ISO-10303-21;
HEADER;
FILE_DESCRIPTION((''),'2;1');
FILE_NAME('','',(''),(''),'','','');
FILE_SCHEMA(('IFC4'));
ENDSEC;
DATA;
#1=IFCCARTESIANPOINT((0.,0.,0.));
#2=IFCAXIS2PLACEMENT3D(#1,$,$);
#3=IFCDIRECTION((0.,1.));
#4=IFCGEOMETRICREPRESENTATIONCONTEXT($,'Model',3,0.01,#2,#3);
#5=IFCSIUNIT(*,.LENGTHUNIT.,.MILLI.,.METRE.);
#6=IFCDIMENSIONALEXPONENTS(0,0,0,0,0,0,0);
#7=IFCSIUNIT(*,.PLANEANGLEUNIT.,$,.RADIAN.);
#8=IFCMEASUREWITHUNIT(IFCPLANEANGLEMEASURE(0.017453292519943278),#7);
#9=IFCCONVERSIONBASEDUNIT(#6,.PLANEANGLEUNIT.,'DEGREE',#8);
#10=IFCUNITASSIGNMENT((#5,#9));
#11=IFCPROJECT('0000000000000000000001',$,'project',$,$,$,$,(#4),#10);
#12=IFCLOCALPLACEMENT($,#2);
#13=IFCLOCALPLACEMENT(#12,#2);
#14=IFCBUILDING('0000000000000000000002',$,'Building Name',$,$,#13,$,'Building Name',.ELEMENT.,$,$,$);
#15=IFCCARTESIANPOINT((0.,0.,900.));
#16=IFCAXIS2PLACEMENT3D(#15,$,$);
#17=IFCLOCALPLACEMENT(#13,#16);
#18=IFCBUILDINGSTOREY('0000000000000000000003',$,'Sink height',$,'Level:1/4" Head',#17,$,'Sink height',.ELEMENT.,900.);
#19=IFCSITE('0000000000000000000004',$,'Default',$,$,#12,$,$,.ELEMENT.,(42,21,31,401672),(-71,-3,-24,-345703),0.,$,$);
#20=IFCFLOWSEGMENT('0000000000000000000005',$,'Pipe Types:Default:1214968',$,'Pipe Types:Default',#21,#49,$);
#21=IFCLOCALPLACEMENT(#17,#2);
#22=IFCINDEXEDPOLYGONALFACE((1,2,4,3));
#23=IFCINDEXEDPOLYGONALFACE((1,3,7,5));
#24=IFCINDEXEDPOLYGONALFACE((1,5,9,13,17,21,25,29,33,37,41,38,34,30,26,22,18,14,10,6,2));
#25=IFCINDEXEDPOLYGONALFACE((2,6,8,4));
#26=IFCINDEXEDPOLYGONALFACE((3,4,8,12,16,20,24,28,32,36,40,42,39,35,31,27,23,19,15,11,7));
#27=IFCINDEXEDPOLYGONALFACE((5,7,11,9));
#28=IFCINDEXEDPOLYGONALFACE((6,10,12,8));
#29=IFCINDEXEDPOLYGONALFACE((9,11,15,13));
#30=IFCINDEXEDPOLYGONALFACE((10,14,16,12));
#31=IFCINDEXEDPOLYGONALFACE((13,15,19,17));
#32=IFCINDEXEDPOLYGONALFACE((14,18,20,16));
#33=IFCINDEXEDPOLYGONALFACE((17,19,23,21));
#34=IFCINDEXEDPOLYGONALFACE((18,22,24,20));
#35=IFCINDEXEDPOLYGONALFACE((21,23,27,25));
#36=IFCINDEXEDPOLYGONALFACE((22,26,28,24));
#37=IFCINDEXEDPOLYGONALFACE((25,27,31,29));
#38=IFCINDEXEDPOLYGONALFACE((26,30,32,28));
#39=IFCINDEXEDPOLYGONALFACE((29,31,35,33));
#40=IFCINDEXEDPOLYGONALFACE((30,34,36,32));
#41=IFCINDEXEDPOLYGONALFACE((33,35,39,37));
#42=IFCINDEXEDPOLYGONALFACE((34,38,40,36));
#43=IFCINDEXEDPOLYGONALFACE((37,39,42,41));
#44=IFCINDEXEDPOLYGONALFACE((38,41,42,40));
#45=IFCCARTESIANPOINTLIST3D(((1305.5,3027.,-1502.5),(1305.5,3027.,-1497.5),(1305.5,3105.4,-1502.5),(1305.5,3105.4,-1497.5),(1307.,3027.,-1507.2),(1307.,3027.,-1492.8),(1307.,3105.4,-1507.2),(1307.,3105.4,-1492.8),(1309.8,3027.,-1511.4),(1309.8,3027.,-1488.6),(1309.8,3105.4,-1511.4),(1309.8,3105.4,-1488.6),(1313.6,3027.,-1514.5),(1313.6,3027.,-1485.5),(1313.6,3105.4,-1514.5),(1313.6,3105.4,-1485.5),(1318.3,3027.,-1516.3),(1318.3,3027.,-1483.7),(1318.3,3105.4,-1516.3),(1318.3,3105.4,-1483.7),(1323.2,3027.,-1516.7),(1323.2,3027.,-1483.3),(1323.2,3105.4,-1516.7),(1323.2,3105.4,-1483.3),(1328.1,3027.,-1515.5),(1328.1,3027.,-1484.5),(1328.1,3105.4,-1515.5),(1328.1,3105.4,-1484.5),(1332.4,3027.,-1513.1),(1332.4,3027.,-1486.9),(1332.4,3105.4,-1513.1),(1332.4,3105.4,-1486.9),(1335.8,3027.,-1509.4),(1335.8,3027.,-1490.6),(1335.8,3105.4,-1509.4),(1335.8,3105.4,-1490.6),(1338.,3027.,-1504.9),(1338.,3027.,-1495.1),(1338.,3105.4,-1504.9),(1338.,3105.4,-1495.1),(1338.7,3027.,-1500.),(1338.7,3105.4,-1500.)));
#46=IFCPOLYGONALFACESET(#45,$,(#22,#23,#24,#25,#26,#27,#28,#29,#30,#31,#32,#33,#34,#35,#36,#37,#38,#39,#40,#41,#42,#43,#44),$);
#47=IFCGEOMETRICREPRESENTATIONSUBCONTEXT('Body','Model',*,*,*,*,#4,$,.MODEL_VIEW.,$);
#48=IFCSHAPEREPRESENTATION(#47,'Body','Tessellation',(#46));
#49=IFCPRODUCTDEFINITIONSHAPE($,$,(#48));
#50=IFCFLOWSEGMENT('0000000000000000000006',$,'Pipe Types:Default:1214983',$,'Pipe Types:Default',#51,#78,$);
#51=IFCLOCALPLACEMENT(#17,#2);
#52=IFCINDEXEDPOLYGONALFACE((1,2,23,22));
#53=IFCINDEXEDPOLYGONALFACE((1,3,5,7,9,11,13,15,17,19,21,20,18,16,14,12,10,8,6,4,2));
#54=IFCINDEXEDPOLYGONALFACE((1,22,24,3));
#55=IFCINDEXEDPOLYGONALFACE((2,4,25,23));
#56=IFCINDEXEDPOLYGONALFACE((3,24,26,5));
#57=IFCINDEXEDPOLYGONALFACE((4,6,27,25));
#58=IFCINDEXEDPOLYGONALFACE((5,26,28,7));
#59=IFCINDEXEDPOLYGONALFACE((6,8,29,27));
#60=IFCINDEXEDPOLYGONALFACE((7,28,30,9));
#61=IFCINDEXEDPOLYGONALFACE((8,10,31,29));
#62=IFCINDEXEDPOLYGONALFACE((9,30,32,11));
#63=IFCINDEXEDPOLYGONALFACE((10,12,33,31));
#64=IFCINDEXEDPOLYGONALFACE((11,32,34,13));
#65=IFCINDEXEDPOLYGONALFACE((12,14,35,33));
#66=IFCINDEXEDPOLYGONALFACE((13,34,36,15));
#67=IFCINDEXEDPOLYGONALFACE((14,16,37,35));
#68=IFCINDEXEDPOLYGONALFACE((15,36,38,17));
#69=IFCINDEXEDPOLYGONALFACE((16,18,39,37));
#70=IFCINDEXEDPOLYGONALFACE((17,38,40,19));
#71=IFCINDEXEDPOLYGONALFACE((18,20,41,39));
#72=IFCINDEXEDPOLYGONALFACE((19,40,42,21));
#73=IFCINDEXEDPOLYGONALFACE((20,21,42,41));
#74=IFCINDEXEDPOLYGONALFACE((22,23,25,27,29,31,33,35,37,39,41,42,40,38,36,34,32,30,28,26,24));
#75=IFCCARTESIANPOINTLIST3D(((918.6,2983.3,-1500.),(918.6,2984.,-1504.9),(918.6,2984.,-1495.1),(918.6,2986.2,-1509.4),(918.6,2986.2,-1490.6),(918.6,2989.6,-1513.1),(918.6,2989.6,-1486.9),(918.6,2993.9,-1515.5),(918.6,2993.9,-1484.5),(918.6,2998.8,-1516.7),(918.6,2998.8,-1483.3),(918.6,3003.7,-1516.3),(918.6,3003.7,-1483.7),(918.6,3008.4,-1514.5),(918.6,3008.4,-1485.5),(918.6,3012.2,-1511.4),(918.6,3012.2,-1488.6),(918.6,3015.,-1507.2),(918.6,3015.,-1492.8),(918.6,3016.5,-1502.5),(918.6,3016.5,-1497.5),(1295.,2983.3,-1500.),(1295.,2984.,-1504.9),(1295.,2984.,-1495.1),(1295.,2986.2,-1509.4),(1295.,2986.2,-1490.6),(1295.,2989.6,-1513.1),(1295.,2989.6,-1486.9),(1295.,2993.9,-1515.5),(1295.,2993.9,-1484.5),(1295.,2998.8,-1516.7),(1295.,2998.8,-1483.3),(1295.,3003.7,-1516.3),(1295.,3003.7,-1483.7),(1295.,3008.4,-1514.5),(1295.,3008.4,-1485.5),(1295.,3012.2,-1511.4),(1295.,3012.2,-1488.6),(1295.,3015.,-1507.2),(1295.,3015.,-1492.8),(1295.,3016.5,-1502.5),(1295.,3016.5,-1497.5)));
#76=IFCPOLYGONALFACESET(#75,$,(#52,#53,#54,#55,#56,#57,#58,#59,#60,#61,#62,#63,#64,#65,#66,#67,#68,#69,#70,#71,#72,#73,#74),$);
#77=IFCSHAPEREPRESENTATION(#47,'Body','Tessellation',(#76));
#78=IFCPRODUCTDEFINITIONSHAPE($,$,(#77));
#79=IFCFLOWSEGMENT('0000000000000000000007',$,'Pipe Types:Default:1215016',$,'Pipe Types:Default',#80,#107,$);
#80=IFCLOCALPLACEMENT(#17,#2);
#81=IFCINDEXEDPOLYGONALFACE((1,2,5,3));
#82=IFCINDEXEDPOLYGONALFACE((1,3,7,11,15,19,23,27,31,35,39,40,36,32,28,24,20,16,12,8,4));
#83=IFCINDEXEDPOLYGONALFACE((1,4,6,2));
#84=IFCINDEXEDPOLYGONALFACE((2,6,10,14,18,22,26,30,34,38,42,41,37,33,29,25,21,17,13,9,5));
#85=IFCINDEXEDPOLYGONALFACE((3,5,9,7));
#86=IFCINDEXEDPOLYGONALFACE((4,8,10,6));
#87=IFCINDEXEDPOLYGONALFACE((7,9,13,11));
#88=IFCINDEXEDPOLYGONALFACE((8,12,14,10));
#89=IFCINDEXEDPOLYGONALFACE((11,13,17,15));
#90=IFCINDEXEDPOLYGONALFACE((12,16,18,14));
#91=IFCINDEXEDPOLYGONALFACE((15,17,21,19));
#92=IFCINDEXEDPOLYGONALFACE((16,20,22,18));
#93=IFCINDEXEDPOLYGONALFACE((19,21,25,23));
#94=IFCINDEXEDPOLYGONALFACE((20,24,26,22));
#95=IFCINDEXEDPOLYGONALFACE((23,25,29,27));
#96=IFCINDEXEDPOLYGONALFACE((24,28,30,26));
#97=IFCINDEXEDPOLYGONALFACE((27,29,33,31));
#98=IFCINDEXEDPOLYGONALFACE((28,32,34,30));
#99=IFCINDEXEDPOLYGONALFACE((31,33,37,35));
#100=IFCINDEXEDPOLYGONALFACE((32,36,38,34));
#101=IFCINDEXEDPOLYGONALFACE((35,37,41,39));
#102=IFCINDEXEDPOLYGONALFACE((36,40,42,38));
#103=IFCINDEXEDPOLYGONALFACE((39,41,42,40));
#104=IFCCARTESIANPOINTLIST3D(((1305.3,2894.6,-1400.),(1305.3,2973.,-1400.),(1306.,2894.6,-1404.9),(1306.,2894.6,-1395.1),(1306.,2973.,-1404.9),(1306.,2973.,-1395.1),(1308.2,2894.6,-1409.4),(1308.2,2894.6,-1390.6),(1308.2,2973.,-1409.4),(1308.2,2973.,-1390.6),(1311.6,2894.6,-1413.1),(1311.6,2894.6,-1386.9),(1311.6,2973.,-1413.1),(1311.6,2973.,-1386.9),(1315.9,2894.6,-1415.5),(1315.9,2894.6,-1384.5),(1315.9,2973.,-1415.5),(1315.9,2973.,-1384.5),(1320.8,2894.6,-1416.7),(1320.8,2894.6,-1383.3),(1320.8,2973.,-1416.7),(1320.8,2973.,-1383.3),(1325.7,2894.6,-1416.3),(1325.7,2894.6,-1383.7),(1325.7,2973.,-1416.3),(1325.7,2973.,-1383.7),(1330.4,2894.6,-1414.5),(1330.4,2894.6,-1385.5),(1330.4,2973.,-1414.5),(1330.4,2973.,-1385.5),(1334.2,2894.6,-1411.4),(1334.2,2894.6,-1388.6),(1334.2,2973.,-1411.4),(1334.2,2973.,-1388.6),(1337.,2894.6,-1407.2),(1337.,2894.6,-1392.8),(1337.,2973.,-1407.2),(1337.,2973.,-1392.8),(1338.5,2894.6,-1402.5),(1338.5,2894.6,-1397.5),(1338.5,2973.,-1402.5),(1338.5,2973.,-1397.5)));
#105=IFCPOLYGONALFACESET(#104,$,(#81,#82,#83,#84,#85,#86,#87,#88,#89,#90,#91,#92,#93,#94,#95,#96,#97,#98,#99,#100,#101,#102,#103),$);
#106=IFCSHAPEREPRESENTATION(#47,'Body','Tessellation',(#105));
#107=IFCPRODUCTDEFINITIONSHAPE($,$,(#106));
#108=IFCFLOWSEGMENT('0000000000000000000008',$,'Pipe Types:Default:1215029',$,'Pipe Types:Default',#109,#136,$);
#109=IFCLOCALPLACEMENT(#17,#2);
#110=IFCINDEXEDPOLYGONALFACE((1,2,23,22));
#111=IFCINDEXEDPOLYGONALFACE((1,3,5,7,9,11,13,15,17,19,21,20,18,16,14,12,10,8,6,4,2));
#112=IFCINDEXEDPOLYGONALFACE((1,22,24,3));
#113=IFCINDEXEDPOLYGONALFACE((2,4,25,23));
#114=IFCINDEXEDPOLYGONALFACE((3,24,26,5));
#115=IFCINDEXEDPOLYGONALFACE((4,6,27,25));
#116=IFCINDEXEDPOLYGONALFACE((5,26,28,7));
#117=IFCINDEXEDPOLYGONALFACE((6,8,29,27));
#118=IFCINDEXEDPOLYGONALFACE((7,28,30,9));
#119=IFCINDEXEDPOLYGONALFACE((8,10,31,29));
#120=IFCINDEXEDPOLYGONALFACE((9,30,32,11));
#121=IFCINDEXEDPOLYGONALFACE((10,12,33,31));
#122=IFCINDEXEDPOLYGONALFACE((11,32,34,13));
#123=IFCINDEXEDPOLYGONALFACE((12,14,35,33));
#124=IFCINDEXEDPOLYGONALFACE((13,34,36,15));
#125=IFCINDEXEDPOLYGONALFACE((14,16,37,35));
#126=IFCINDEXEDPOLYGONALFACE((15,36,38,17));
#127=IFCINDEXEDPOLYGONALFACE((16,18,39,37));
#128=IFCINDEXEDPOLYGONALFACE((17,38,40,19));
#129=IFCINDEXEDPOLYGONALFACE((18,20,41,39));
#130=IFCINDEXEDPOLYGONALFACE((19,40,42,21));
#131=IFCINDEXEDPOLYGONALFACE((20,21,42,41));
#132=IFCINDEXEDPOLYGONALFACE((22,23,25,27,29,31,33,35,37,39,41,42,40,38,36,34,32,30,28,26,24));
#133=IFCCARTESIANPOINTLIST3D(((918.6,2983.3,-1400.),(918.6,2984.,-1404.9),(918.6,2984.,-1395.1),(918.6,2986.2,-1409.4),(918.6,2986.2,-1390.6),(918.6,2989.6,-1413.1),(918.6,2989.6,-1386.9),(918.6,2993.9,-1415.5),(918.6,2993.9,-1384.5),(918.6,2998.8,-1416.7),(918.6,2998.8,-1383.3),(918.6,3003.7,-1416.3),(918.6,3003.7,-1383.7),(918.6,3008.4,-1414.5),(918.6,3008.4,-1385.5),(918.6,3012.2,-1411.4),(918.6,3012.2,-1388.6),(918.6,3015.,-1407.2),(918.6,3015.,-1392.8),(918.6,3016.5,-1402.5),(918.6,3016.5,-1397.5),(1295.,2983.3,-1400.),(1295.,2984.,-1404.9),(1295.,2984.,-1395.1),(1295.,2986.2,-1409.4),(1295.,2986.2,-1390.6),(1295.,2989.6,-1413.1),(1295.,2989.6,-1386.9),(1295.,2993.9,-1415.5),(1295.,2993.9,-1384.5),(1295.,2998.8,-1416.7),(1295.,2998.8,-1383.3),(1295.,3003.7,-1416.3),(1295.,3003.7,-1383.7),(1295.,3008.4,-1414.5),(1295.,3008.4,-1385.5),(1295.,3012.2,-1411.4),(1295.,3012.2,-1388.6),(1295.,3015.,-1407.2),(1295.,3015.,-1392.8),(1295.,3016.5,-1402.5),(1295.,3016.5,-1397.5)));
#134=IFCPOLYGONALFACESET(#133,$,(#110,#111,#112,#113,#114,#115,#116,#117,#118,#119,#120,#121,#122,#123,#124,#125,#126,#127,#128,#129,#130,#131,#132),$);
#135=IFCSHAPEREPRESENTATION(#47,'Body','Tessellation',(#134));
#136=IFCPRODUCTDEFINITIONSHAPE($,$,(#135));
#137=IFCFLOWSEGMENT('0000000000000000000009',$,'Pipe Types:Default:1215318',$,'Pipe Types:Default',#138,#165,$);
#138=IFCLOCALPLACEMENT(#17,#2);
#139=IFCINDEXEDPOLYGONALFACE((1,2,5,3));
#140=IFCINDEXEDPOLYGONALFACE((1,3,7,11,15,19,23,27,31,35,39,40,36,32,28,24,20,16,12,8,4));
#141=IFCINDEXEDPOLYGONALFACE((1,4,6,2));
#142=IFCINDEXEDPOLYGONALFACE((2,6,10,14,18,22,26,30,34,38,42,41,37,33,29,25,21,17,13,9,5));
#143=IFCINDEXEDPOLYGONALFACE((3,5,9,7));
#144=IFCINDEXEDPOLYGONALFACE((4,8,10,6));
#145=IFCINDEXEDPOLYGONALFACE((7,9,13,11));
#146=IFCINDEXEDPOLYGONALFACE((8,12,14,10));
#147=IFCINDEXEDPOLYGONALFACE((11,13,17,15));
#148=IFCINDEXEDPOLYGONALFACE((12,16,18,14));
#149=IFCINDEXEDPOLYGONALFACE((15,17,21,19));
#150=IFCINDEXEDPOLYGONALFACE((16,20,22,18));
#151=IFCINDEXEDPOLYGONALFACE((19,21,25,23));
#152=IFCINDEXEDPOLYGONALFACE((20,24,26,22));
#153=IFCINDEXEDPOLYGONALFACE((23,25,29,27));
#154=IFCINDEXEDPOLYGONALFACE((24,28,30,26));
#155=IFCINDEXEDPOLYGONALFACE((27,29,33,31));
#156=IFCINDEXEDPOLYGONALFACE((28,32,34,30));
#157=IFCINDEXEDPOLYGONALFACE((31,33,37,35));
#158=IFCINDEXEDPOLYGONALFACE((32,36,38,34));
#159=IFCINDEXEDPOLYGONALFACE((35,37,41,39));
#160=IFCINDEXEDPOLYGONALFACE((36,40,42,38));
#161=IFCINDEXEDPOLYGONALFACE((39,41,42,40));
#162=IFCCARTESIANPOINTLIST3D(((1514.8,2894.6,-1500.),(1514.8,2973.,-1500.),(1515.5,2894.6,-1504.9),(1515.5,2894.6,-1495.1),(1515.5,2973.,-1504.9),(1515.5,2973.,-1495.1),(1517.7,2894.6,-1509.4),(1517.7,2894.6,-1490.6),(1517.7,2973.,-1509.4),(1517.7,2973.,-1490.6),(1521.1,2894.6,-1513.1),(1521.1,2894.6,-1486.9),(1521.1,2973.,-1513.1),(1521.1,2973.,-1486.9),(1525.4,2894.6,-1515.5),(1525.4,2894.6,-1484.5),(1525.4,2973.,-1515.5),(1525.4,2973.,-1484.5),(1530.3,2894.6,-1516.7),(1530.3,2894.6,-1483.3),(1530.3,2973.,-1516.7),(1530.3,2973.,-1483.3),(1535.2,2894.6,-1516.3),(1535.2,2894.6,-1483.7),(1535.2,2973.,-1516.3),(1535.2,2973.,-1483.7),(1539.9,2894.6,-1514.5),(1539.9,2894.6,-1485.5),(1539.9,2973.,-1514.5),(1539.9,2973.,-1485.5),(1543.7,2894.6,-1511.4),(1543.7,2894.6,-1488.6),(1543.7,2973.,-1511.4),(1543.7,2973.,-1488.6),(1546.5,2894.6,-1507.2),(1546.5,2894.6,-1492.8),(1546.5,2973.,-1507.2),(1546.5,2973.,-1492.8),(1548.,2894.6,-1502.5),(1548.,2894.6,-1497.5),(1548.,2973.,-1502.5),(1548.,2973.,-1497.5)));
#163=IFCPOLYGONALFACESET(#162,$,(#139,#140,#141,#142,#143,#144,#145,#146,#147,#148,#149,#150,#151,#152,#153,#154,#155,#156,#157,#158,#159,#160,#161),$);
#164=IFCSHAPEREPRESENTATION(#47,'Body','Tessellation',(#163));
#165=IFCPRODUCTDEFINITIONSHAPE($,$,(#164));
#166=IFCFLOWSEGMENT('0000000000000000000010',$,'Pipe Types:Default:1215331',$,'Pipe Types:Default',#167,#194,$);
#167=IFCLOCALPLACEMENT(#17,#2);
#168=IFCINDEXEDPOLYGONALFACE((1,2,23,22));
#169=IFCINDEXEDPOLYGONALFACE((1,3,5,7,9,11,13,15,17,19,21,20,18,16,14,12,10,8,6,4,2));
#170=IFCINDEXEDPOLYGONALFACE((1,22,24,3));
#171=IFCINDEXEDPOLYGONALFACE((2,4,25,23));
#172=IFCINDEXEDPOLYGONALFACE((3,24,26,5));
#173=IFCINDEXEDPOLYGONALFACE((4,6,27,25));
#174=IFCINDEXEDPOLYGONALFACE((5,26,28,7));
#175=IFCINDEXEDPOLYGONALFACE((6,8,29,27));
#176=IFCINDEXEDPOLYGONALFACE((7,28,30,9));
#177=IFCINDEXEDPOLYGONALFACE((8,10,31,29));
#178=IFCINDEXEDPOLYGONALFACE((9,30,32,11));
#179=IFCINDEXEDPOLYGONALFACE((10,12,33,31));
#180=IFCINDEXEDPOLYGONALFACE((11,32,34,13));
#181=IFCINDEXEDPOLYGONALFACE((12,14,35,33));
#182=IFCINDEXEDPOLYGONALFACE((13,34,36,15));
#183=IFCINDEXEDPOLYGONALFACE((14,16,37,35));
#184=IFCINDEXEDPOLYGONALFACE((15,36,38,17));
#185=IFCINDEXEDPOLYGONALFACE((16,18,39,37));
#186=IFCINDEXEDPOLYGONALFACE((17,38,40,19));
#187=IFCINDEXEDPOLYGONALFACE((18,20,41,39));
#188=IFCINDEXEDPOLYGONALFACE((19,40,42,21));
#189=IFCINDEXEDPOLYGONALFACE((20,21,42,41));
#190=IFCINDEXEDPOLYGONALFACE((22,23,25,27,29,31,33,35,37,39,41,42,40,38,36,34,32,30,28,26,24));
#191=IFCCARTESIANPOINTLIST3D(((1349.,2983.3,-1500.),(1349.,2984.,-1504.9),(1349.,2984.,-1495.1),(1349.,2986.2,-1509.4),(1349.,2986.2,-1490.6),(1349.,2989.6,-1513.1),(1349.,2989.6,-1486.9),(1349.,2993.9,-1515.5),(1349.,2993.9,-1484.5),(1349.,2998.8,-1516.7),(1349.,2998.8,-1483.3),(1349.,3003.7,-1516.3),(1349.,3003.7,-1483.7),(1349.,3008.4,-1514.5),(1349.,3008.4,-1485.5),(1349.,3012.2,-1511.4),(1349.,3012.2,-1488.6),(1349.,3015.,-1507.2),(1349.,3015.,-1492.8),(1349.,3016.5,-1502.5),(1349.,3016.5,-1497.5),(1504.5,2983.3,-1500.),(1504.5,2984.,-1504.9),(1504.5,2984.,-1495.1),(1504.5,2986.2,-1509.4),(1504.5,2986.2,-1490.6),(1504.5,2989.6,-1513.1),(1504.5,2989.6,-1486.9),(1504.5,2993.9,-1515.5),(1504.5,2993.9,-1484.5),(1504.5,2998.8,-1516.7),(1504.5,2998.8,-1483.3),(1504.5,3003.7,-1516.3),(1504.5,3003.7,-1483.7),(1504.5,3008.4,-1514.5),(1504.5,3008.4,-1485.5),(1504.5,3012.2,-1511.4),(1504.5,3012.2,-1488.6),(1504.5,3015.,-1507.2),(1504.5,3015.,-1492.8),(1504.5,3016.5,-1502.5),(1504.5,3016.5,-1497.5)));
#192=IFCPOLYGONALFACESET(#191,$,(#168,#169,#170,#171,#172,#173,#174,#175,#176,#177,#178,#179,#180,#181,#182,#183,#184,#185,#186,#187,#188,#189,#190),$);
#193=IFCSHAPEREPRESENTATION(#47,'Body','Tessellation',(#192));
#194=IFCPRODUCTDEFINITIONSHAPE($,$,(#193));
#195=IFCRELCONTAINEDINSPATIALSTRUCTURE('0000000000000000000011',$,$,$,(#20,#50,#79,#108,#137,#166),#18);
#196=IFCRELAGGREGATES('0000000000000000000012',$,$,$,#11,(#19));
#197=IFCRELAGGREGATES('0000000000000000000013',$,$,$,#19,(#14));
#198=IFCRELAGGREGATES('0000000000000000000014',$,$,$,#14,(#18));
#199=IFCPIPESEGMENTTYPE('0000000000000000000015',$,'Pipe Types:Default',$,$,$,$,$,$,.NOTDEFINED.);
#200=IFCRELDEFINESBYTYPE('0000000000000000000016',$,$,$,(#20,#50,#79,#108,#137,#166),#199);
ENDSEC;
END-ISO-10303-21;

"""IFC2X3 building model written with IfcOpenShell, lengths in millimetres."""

from ifc_helpers import new_model, entity, si_unit, converted_unit, direction, frame, frame_2d, origin, origin_2d_with_axis, place, context, subcontext, project, spatial, circle, extrude, type_object, element, save


model = new_model("IFC2X3")

# Units and contexts
model_context = context("Model", 3, precision=0.01, world=origin(), true_north=direction((0.0, 1.0)))
body_context = subcontext(model_context, "Body", "Model", "MODEL_VIEW")
ifc_project = project(units=[si_unit("LENGTHUNIT", "METRE", prefix="MILLI"), converted_unit("PLANEANGLEUNIT", "DEGREE", entity("IfcPlaneAngleMeasure", 0.017453292519943278), si_unit("PLANEANGLEUNIT", "RADIAN"), dimensions=[0, 0, 0, 0, 0, 0, 0])], contexts=[model_context])

# Site, building, storey
site_placement = place(None, origin())
site = spatial("IfcSite", under=ifc_project, at=site_placement, Name="Default", CompositionType="ELEMENT", RefLatitude=(42, 21, 31, 401672), RefLongitude=(-71, -3, -24, -345703), RefElevation=0.0)
building_placement = place(site_placement, origin())
building = spatial("IfcBuilding", under=site, at=building_placement, Name="Building Name", LongName="Building Name", CompositionType="ELEMENT")
storey_placement = place(building_placement, frame((0.0, 0.0, 900.0)))
storey = spatial("IfcBuildingStorey", under=building, at=storey_placement, Name="Sink height", ObjectType="Level:1/4\" Head", LongName="Sink height", CompositionType="ELEMENT", Elevation=900.0)

# Flow segments
pipe_segment_type = type_object("IfcPipeSegmentType", Name="Pipe Types:Default", PredefinedType="NOTDEFINED")
flow_segment_1_placement = place(storey_placement, origin())
element("IfcFlowSegment", 1, at=flow_segment_1_placement, inside=storey, type_object=pipe_segment_type, Name="Pipe Types:Default:1214968", ObjectType="Pipe Types:Default", context=body_context, shape_type="SweptSolid", body=[
    extrude(circle(Radius=16.7, at=origin_2d_with_axis()), frame((1322.0, 3027.0, -1500.0), z_axis=(0.0, 1.0, 0.0), x_axis=(1.0, 0.0, 0.0)), (0.0, 0.0, 1.0), 78.4),
])
flow_segment_2_placement = place(storey_placement, origin())
element("IfcFlowSegment", 2, at=flow_segment_2_placement, inside=storey, type_object=pipe_segment_type, Name="Pipe Types:Default:1214983", ObjectType="Pipe Types:Default", context=body_context, shape_type="SweptSolid", body=[
    extrude(circle(Radius=16.7, at=origin_2d_with_axis()), frame((918.6, 3000.0, -1500.0), z_axis=(1.0, 0.0, 0.0), x_axis=(0.0, -1.0, 0.0)), (0.0, 0.0, 1.0), 376.5),
])
flow_segment_3_placement = place(storey_placement, origin())
element("IfcFlowSegment", 3, at=flow_segment_3_placement, inside=storey, type_object=pipe_segment_type, Name="Pipe Types:Default:1215016", ObjectType="Pipe Types:Default", context=body_context, shape_type="SweptSolid", body=[
    extrude(circle(Radius=16.7, at=frame_2d((0.0, 0.0), x_axis=(1.0, 0.0))), frame((1322.0, 2894.6, -1400.0), z_axis=(0.0, 1.0, 0.0), x_axis=(-1.0, 0.0, 0.0)), (0.0, 0.0, 1.0), 78.4),
])
flow_segment_4_placement = place(storey_placement, origin())
element("IfcFlowSegment", 4, at=flow_segment_4_placement, inside=storey, type_object=pipe_segment_type, Name="Pipe Types:Default:1215029", ObjectType="Pipe Types:Default", context=body_context, shape_type="SweptSolid", body=[
    extrude(circle(Radius=16.7, at=origin_2d_with_axis()), frame((918.6, 3000.0, -1400.0), z_axis=(1.0, 0.0, 0.0), x_axis=(0.0, -1.0, 0.0)), (0.0, 0.0, 1.0), 376.5),
])
flow_segment_5_placement = place(storey_placement, origin())
element("IfcFlowSegment", 5, at=flow_segment_5_placement, inside=storey, type_object=pipe_segment_type, Name="Pipe Types:Default:1215318", ObjectType="Pipe Types:Default", context=body_context, shape_type="SweptSolid", body=[
    extrude(circle(Radius=16.7, at=frame_2d((0.0, 0.0), x_axis=(1.0, 0.0))), frame((1531.5, 2894.6, -1500.0), z_axis=(0.0, 1.0, 0.0), x_axis=(-1.0, 0.0, 0.0)), (0.0, 0.0, 1.0), 78.4),
])
flow_segment_6_placement = place(storey_placement, origin())
element("IfcFlowSegment", 6, at=flow_segment_6_placement, inside=storey, type_object=pipe_segment_type, Name="Pipe Types:Default:1215331", ObjectType="Pipe Types:Default", context=body_context, shape_type="SweptSolid", body=[
    extrude(circle(Radius=16.7, at=origin_2d_with_axis()), frame((1349.0, 3000.0, -1500.0), z_axis=(1.0, 0.0, 0.0), x_axis=(0.0, -1.0, 0.0)), (0.0, 0.0, 1.0), 155.5),
])

save(model, "model.ifc")
